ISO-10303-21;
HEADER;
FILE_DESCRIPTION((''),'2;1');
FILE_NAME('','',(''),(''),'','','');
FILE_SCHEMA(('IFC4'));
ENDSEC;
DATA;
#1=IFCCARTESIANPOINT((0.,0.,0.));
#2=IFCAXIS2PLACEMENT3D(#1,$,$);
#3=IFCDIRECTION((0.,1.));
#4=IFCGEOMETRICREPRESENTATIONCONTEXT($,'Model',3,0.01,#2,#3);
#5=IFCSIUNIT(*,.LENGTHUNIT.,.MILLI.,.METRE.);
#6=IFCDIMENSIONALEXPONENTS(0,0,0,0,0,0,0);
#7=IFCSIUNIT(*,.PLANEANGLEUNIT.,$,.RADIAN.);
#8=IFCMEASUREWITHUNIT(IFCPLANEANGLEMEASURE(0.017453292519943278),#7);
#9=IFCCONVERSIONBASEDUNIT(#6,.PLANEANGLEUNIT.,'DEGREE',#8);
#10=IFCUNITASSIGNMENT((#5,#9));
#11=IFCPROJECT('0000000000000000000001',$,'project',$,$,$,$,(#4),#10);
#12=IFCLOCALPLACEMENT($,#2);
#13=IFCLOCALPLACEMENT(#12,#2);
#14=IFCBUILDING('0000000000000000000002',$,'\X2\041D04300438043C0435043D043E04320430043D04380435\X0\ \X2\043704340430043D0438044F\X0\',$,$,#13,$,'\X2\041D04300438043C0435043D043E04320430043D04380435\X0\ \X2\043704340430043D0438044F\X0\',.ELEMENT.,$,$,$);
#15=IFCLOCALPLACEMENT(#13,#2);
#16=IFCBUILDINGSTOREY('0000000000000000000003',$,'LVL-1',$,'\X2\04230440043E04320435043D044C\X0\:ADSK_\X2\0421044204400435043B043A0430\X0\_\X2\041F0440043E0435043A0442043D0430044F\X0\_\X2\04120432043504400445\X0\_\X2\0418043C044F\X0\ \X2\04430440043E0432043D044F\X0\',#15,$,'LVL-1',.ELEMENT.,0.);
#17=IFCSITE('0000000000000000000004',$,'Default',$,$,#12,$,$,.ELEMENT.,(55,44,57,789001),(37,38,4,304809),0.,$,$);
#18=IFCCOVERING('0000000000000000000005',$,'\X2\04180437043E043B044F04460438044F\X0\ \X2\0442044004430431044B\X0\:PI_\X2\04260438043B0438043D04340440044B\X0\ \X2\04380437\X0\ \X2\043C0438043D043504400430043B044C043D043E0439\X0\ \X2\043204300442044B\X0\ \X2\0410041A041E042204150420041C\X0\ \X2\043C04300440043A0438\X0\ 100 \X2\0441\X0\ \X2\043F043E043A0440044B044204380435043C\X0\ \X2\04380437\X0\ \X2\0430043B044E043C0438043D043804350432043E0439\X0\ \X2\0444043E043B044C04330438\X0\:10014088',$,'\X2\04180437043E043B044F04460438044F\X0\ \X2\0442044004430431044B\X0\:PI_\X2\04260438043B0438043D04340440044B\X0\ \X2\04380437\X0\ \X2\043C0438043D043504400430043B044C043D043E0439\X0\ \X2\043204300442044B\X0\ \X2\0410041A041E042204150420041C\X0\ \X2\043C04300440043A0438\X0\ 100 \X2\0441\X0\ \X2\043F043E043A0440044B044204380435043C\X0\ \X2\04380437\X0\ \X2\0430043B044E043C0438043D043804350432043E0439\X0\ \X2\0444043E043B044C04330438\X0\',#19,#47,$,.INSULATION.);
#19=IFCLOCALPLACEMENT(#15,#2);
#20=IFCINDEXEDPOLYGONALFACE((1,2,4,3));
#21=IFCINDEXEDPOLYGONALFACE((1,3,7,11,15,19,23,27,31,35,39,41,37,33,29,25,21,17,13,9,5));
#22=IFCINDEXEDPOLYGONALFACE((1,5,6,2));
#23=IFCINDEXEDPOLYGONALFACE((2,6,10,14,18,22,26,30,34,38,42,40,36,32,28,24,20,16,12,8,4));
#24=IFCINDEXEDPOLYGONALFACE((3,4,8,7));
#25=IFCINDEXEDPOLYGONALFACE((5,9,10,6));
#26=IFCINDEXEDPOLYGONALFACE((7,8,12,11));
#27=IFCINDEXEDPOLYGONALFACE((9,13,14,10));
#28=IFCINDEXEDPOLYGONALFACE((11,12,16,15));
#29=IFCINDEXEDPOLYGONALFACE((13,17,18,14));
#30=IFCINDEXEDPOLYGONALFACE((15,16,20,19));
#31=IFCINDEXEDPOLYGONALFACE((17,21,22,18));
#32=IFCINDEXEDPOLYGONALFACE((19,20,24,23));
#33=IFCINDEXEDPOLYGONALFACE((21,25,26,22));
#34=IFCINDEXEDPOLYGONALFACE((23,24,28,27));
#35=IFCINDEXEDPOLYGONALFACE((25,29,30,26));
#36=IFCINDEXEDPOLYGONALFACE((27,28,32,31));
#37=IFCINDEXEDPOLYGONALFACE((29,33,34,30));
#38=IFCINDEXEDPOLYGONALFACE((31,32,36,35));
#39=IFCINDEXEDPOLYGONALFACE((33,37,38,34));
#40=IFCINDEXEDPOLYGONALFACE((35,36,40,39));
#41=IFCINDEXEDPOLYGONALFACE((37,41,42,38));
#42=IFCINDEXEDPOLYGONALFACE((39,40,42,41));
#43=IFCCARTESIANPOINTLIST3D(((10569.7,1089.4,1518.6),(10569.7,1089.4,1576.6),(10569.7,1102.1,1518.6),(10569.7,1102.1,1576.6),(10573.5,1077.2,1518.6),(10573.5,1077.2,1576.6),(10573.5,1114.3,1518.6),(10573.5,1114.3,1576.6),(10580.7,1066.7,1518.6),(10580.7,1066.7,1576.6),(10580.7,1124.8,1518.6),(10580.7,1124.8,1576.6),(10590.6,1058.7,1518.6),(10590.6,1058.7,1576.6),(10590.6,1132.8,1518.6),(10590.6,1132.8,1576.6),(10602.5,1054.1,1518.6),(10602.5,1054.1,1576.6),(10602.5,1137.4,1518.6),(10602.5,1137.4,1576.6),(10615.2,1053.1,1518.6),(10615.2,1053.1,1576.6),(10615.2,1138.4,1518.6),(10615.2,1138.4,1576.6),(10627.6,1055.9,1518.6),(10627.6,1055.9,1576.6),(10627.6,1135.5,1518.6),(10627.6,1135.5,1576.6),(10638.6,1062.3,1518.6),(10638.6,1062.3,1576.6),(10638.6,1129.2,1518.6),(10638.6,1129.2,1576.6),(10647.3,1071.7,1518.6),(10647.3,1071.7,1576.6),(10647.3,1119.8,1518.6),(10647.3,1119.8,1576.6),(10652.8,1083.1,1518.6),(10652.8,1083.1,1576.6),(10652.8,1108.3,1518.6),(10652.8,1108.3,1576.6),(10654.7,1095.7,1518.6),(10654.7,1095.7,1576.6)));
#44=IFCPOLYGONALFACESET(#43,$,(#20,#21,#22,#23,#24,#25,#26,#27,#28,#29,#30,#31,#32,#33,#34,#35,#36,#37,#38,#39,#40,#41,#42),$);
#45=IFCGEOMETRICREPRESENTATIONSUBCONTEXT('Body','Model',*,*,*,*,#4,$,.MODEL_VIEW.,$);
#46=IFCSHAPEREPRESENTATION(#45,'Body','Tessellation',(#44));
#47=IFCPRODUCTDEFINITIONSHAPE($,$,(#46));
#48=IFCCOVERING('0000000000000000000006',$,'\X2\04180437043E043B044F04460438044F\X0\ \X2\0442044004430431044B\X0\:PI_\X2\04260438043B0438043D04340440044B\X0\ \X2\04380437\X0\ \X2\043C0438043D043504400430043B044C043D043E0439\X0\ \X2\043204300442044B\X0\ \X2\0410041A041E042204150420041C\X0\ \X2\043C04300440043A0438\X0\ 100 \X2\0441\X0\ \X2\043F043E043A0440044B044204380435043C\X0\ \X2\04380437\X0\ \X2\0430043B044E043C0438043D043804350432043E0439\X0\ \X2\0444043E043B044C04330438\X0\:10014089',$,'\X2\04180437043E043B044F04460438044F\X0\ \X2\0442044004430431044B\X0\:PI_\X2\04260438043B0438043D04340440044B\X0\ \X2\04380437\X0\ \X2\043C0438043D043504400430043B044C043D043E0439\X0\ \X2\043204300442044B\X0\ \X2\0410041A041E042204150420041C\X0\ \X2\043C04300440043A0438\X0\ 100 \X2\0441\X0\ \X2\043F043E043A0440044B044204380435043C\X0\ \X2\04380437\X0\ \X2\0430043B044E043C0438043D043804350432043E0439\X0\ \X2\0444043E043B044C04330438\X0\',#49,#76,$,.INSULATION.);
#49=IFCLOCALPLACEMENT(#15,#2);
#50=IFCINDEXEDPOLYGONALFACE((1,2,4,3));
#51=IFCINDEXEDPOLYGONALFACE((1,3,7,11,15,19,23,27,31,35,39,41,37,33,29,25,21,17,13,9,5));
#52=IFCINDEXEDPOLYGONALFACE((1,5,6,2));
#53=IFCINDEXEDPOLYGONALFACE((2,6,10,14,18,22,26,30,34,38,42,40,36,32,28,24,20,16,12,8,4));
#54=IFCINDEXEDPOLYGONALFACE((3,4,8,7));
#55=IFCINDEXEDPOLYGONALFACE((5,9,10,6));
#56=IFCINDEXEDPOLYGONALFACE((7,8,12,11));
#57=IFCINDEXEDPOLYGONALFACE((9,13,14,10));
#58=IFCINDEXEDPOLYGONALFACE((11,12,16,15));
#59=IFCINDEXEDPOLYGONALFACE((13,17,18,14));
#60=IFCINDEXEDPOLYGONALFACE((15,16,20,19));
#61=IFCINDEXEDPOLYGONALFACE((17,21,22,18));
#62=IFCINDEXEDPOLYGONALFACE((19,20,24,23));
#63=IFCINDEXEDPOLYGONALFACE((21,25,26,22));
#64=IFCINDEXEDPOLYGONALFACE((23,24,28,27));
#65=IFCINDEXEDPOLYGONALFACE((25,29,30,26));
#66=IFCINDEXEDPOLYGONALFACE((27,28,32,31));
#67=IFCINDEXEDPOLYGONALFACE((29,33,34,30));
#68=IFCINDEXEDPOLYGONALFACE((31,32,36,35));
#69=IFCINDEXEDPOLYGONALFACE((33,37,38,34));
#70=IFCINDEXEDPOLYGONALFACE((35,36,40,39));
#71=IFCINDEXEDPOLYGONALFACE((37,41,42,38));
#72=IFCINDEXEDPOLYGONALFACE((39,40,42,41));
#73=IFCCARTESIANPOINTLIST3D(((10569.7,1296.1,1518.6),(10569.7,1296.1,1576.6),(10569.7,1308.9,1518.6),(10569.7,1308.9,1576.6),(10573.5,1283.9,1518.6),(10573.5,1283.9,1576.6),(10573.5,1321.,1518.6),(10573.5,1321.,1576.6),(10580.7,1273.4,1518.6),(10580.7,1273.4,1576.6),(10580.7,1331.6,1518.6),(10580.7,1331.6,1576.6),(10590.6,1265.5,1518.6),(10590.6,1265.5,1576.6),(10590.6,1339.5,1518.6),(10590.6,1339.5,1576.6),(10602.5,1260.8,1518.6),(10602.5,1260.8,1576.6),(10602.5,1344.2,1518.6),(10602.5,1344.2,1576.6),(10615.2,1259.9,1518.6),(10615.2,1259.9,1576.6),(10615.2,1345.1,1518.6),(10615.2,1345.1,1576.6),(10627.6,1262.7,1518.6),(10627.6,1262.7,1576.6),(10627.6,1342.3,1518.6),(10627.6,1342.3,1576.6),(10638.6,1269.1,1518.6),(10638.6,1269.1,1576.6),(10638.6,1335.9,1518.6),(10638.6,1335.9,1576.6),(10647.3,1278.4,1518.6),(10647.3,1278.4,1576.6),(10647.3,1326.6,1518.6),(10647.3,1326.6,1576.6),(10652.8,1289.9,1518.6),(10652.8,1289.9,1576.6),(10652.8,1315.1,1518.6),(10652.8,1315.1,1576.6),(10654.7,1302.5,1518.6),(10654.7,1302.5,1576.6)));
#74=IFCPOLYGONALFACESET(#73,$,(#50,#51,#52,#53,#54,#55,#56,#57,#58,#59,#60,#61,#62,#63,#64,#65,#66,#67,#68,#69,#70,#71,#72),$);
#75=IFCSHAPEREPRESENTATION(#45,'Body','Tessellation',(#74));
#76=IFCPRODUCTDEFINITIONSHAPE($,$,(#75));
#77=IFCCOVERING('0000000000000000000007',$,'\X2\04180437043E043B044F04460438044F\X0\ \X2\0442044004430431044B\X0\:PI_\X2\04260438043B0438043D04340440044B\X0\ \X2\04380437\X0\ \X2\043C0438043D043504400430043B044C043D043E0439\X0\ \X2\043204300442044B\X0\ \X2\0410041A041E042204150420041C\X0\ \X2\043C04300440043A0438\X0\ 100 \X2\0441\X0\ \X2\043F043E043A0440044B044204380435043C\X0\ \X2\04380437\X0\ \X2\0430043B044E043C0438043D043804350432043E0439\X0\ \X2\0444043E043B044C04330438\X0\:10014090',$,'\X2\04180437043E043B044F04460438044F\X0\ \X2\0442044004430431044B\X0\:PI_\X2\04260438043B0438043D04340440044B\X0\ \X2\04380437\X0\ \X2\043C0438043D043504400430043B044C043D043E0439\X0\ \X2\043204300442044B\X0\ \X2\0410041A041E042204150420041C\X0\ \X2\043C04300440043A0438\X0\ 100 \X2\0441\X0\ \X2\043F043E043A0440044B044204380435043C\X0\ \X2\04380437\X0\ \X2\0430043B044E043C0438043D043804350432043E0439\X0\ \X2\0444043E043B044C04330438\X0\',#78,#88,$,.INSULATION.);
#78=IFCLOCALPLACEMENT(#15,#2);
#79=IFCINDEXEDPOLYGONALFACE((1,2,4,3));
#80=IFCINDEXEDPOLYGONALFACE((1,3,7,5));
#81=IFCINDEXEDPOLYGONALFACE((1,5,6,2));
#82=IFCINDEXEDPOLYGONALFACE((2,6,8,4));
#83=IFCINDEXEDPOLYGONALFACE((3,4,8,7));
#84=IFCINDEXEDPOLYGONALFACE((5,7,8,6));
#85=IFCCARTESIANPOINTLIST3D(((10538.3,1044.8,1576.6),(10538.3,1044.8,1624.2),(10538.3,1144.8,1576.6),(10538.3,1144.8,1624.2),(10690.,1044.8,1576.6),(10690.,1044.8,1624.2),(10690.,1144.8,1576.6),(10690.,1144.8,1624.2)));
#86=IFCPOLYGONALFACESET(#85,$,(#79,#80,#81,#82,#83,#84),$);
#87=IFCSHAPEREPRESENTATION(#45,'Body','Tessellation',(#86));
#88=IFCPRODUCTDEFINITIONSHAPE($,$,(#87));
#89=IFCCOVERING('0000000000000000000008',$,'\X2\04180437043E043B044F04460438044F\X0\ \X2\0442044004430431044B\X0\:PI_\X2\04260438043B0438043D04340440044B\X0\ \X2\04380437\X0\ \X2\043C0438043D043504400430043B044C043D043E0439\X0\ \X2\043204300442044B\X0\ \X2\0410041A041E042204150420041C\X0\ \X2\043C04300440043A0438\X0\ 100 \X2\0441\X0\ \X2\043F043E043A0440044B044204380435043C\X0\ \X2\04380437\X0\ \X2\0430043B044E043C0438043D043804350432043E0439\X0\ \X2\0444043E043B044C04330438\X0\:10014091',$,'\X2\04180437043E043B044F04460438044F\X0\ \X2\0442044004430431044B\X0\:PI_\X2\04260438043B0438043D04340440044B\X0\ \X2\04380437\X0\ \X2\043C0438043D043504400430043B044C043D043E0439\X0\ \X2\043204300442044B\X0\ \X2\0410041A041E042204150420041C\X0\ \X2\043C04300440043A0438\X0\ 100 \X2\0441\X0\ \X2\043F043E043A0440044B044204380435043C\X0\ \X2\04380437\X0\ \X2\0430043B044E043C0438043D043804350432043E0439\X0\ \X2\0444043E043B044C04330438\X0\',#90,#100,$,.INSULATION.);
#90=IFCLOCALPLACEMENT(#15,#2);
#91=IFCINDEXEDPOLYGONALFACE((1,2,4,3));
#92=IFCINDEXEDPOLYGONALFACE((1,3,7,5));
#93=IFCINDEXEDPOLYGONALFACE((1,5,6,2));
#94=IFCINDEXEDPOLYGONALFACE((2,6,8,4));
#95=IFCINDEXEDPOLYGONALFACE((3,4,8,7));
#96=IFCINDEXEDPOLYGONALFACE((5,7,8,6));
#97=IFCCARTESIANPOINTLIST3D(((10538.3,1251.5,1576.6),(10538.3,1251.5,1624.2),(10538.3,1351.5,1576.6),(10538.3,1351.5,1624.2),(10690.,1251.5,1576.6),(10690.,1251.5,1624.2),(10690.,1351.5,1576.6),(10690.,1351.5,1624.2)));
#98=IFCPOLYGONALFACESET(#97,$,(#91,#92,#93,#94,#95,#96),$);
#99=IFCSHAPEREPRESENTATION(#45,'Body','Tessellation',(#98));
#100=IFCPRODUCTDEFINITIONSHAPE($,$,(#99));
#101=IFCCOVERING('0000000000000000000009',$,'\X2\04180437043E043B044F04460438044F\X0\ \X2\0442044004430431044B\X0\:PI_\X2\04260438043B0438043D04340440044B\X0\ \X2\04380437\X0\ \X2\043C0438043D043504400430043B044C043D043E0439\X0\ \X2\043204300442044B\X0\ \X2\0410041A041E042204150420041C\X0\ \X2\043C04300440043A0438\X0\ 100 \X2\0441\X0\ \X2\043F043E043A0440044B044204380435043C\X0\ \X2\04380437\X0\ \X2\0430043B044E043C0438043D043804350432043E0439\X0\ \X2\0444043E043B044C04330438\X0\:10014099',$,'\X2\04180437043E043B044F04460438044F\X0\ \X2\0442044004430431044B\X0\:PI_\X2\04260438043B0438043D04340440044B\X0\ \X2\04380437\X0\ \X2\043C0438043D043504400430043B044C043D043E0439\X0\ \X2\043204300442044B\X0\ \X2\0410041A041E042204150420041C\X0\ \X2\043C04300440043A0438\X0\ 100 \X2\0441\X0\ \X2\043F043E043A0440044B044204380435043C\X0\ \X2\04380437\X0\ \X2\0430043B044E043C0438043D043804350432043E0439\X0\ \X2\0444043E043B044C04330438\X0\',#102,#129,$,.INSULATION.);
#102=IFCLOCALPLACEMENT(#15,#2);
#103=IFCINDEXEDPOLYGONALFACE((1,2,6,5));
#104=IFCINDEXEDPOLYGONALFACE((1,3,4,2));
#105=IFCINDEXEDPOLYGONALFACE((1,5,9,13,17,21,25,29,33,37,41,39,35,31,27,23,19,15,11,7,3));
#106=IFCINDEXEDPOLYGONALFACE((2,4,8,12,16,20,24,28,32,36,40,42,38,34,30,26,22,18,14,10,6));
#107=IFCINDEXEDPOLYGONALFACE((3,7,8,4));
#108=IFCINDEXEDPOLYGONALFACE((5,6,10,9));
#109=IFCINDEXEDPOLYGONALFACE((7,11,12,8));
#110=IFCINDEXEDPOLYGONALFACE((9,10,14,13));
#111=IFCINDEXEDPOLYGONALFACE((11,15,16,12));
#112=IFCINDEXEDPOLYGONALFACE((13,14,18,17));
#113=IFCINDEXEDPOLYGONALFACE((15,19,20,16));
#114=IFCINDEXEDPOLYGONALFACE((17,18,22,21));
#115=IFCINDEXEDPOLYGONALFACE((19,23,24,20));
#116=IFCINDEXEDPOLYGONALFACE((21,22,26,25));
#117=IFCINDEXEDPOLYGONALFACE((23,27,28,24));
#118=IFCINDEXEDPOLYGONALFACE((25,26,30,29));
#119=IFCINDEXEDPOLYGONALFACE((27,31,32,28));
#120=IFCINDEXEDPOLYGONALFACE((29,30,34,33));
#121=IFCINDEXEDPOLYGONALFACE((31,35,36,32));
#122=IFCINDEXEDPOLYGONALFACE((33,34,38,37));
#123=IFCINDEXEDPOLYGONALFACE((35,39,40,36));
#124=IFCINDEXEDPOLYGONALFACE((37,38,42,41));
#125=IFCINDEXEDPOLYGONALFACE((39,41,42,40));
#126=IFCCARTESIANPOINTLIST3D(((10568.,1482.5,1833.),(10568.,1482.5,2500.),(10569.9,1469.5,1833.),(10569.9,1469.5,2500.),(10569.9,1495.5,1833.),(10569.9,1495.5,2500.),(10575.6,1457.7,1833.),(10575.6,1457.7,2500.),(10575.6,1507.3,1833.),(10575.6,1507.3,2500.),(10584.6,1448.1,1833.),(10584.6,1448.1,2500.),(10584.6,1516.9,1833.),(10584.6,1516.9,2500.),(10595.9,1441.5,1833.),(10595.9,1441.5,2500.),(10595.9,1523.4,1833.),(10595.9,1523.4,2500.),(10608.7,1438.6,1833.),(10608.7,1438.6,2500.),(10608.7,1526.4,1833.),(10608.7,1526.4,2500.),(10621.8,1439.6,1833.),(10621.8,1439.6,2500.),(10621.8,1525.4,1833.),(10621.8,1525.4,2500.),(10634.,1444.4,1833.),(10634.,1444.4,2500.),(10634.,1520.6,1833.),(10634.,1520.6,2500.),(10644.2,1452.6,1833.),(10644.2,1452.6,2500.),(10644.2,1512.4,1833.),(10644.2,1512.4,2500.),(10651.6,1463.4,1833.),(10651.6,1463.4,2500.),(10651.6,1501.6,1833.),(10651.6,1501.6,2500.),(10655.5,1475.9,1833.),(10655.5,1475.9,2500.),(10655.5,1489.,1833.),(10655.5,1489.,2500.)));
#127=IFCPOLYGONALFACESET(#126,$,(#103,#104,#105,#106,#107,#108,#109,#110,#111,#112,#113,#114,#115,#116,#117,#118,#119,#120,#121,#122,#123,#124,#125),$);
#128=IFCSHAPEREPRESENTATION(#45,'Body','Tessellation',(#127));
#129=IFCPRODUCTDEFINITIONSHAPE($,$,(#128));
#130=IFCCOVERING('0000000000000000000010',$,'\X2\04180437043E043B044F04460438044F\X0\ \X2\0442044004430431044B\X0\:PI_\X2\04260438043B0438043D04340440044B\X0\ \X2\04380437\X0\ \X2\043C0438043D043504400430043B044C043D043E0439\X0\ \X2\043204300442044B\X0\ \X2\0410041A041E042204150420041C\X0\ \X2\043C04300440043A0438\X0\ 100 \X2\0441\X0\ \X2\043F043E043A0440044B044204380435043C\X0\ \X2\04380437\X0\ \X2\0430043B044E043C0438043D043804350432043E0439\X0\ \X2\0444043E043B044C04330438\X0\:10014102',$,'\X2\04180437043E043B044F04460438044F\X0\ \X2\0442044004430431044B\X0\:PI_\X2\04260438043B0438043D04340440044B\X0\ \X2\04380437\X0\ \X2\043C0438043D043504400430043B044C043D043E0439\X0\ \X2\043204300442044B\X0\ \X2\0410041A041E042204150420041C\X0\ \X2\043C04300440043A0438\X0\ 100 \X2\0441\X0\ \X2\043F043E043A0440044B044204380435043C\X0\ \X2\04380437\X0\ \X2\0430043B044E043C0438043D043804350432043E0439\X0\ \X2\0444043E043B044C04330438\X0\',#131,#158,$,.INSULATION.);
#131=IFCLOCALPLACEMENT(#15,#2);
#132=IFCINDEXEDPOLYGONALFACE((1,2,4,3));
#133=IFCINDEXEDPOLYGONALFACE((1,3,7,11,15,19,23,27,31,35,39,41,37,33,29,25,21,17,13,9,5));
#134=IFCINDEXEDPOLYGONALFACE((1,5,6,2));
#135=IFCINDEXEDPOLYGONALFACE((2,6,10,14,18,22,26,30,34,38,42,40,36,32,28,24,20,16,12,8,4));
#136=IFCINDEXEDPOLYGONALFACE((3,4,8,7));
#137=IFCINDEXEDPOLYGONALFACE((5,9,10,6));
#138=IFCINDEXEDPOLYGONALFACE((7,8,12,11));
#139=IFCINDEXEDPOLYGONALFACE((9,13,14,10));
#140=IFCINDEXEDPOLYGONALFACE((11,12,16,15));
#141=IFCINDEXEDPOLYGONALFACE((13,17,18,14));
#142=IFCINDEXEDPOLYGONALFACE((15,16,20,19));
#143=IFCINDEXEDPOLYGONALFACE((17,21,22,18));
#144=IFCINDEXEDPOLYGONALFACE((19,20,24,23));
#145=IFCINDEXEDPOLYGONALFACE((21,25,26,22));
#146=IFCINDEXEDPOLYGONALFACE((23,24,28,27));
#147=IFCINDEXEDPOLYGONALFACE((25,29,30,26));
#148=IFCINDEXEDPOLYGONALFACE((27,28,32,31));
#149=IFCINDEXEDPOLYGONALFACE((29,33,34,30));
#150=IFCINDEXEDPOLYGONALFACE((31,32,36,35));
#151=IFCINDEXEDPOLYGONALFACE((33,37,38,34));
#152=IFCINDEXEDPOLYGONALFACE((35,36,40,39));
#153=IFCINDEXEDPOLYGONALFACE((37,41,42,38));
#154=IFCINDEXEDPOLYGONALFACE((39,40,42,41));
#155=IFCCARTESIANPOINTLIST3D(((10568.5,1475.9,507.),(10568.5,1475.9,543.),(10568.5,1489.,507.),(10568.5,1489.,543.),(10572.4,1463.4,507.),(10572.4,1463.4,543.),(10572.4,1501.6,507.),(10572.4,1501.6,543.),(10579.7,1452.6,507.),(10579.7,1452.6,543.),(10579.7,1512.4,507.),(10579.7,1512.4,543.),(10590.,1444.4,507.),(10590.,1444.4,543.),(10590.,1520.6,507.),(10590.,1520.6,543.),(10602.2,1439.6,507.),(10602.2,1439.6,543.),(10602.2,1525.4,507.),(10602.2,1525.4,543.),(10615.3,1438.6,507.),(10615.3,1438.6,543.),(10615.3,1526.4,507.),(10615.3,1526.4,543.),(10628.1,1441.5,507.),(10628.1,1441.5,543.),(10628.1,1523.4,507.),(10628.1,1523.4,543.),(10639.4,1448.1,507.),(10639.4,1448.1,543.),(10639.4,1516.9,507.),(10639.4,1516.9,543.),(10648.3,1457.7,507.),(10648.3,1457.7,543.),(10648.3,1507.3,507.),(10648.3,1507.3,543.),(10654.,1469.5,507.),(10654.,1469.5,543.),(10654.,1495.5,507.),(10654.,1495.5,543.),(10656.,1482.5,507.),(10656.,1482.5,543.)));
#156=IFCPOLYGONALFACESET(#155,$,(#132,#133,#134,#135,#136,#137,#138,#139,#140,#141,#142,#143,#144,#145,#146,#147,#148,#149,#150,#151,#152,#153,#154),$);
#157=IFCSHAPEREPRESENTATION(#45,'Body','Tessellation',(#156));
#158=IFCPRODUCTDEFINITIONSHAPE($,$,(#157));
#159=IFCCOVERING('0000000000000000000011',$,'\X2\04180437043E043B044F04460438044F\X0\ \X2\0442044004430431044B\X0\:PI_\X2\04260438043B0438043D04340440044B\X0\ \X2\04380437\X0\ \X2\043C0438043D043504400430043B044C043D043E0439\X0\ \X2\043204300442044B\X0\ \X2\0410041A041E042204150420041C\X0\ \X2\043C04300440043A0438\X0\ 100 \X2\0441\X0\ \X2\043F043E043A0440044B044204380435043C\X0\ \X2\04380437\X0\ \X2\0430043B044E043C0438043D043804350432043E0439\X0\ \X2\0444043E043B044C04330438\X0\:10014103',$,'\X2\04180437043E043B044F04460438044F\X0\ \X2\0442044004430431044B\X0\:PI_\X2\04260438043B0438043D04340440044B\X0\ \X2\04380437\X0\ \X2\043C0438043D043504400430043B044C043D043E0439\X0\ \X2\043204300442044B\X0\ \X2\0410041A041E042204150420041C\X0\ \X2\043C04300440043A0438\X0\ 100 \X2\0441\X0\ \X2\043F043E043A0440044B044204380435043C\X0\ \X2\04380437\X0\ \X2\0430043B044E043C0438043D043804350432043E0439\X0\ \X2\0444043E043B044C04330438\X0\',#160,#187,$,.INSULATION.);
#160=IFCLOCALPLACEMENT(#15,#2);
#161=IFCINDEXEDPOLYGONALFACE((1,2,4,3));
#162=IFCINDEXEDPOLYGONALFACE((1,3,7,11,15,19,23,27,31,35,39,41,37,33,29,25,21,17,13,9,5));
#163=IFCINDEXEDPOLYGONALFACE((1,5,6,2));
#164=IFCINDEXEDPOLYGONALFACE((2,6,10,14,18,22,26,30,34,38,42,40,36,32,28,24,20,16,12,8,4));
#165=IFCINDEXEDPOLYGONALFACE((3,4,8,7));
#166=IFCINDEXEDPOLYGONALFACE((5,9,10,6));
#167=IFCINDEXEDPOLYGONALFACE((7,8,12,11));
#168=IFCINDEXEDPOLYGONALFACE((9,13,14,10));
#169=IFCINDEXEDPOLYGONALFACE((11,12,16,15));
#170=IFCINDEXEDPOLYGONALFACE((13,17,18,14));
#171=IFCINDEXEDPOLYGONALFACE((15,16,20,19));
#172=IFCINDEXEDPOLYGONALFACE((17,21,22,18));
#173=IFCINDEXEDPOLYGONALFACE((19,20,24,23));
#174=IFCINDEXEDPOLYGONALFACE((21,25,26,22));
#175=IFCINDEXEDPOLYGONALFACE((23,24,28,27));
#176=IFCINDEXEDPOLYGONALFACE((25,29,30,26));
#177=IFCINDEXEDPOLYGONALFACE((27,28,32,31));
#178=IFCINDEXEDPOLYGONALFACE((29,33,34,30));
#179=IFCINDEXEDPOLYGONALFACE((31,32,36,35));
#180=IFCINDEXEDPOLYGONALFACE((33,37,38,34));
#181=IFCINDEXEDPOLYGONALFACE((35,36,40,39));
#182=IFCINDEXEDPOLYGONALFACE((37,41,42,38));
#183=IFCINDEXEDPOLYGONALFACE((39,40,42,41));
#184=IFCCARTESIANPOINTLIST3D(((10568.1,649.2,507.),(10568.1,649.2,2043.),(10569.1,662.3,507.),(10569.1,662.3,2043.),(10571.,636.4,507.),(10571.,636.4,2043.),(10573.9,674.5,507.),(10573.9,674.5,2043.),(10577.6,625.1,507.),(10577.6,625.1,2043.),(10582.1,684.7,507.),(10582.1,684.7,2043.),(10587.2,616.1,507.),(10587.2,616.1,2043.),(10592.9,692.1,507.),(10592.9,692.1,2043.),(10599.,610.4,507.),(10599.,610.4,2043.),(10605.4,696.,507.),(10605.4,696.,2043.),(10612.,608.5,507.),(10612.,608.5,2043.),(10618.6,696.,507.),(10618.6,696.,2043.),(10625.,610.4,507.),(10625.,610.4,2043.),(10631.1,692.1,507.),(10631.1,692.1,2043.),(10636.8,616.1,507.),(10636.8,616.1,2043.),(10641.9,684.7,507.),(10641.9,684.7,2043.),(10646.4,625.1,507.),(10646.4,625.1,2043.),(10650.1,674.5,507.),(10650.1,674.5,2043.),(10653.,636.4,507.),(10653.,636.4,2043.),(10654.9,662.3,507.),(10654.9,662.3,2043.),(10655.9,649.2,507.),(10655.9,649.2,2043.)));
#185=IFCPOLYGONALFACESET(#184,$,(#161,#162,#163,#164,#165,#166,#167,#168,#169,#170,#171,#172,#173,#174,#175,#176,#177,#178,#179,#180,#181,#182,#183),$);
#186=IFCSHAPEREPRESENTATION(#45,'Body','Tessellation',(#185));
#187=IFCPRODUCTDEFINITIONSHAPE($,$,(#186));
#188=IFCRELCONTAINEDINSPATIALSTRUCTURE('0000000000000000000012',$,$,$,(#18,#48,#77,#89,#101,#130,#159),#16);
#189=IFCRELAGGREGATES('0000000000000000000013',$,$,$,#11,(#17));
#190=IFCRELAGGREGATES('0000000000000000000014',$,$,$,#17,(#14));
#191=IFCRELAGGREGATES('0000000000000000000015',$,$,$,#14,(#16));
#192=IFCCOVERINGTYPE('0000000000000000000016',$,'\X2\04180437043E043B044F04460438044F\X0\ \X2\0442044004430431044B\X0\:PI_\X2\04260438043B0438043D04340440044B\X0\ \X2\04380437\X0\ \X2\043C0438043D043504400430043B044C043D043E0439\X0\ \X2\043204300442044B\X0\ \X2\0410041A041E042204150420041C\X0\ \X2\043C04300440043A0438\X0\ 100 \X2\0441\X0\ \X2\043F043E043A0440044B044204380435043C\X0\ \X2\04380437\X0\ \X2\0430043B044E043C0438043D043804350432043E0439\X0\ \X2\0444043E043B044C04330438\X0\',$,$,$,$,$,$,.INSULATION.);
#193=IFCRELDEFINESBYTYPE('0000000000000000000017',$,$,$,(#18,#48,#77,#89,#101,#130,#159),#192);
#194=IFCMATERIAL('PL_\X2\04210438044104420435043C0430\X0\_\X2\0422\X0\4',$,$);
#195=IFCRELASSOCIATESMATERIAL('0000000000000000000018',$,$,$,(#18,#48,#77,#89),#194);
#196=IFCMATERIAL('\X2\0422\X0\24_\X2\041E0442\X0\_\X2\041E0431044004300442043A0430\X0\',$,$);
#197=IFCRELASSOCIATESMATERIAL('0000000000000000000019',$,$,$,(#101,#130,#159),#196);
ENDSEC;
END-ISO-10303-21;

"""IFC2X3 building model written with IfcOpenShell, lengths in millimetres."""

from ifc_helpers import new_model, entity, si_unit, converted_unit, direction, frame, frame_2d, origin, origin_2d_with_axis, place, context, subcontext, project, spatial, rectangle, circle, extrude, material, type_object, element, save


model = new_model("IFC2X3")

# Units and contexts
model_context = context("Model", 3, precision=0.01, world=origin(), true_north=direction((0.0, 1.0)))
body_context = subcontext(model_context, "Body", "Model", "MODEL_VIEW")
ifc_project = project(units=[si_unit("LENGTHUNIT", "METRE", prefix="MILLI"), converted_unit("PLANEANGLEUNIT", "DEGREE", entity("IfcPlaneAngleMeasure", 0.017453292519943278), si_unit("PLANEANGLEUNIT", "RADIAN"), dimensions=[0, 0, 0, 0, 0, 0, 0])], contexts=[model_context])

# Site, building, storey
site_placement = place(None, origin())
site = spatial("IfcSite", under=ifc_project, at=site_placement, Name="Default", CompositionType="ELEMENT", RefLatitude=(55, 44, 57, 789001), RefLongitude=(37, 38, 4, 304809), RefElevation=0.0)
building_placement = place(site_placement, origin())
building = spatial("IfcBuilding", under=site, at=building_placement, Name="Наименование здания", LongName="Наименование здания", CompositionType="ELEMENT")
storey_placement = place(building_placement, origin())
storey = spatial("IfcBuildingStorey", under=building, at=storey_placement, Name="LVL-1", ObjectType="Уровень:ADSK_Стрелка_Проектная_Вверх_Имя уровня", LongName="LVL-1", CompositionType="ELEMENT", Elevation=0.0)

# Coverings
ifc_material_1 = material(Name="PL_Система_Т4")
covering_type = type_object("IfcCoveringType", Name="Изоляция трубы:PI_Цилиндры из минеральной ваты АКОТЕРМ марки 100 с покрытием из алюминиевой фольги", PredefinedType="INSULATION")
covering_1_placement = place(storey_placement, origin())
element("IfcCovering", 1, at=covering_1_placement, inside=storey, type_object=covering_type, material=ifc_material_1, Name="Изоляция трубы:PI_Цилиндры из минеральной ваты АКОТЕРМ марки 100 с покрытием из алюминиевой фольги:10014088", ObjectType="Изоляция трубы:PI_Цилиндры из минеральной ваты АКОТЕРМ марки 100 с покрытием из алюминиевой фольги", PredefinedType="INSULATION", context=body_context, shape_type="SweptSolid", body=[
    extrude(circle(Radius=42.8, at=frame_2d((0.0, 0.0), x_axis=(1.0, 0.0))), frame((10612.0, 1095.7, 1518.6)), (0.0, 0.0, 1.0), 58.0),
])
covering_2_placement = place(storey_placement, origin())
element("IfcCovering", 2, at=covering_2_placement, inside=storey, type_object=covering_type, material=ifc_material_1, Name="Изоляция трубы:PI_Цилиндры из минеральной ваты АКОТЕРМ марки 100 с покрытием из алюминиевой фольги:10014089", ObjectType="Изоляция трубы:PI_Цилиндры из минеральной ваты АКОТЕРМ марки 100 с покрытием из алюминиевой фольги", PredefinedType="INSULATION", context=body_context, shape_type="SweptSolid", body=[
    extrude(circle(Radius=42.8, at=origin_2d_with_axis()), frame((10612.0, 1302.5, 1518.6)), (0.0, 0.0, 1.0), 58.0),
])
covering_3_placement = place(storey_placement, origin())
element("IfcCovering", 3, at=covering_3_placement, inside=storey, type_object=covering_type, material=ifc_material_1, Name="Изоляция трубы:PI_Цилиндры из минеральной ваты АКОТЕРМ марки 100 с покрытием из алюминиевой фольги:10014090", ObjectType="Изоляция трубы:PI_Цилиндры из минеральной ваты АКОТЕРМ марки 100 с покрытием из алюминиевой фольги", PredefinedType="INSULATION", context=body_context, shape_type="SweptSolid", body=[
    extrude(rectangle(XDim=151.7, YDim=100.0, at=frame_2d((0.0, 0.0), x_axis=(1.0, 0.0))), frame((10614.1, 1094.8, 1576.6)), (0.0, 0.0, 1.0), 47.7),
])
covering_4_placement = place(storey_placement, origin())
element("IfcCovering", 4, at=covering_4_placement, inside=storey, type_object=covering_type, material=ifc_material_1, Name="Изоляция трубы:PI_Цилиндры из минеральной ваты АКОТЕРМ марки 100 с покрытием из алюминиевой фольги:10014091", ObjectType="Изоляция трубы:PI_Цилиндры из минеральной ваты АКОТЕРМ марки 100 с покрытием из алюминиевой фольги", PredefinedType="INSULATION", context=body_context, shape_type="SweptSolid", body=[
    extrude(rectangle(XDim=151.7, YDim=100.0, at=frame_2d((0.0, 0.0), x_axis=(1.0, 0.0))), frame((10614.1, 1301.5, 1576.6)), (0.0, 0.0, 1.0), 47.7),
])
ifc_material_2 = material(Name="Т24_От_Обратка")
covering_5_placement = place(storey_placement, origin())
element("IfcCovering", 5, at=covering_5_placement, inside=storey, type_object=covering_type, material=ifc_material_2, Name="Изоляция трубы:PI_Цилиндры из минеральной ваты АКОТЕРМ марки 100 с покрытием из алюминиевой фольги:10014099", ObjectType="Изоляция трубы:PI_Цилиндры из минеральной ваты АКОТЕРМ марки 100 с покрытием из алюминиевой фольги", PredefinedType="INSULATION", context=body_context, shape_type="SweptSolid", body=[
    extrude(circle(Radius=44.0, at=frame_2d((0.0, 0.0), x_axis=(1.0, 0.0))), frame((10612.0, 1482.5, 1833.0), z_axis=(0.0, 0.0, 1.0), x_axis=(-1.0, 0.0, 0.0)), (0.0, 0.0, 1.0), 667.0),
])
covering_6_placement = place(storey_placement, origin())
element("IfcCovering", 6, at=covering_6_placement, inside=storey, type_object=covering_type, material=ifc_material_2, Name="Изоляция трубы:PI_Цилиндры из минеральной ваты АКОТЕРМ марки 100 с покрытием из алюминиевой фольги:10014102", ObjectType="Изоляция трубы:PI_Цилиндры из минеральной ваты АКОТЕРМ марки 100 с покрытием из алюминиевой фольги", PredefinedType="INSULATION", context=body_context, shape_type="SweptSolid", body=[
    extrude(circle(Radius=44.0, at=frame_2d((0.0, 0.0), x_axis=(1.0, 0.0))), frame((10612.0, 1482.5, 507.0)), (0.0, 0.0, 1.0), 36.0),
])
covering_7_placement = place(storey_placement, origin())
element("IfcCovering", 7, at=covering_7_placement, inside=storey, type_object=covering_type, material=ifc_material_2, Name="Изоляция трубы:PI_Цилиндры из минеральной ваты АКОТЕРМ марки 100 с покрытием из алюминиевой фольги:10014103", ObjectType="Изоляция трубы:PI_Цилиндры из минеральной ваты АКОТЕРМ марки 100 с покрытием из алюминиевой фольги", PredefinedType="INSULATION", context=body_context, shape_type="SweptSolid", body=[
    extrude(circle(Radius=44.0, at=frame_2d((0.0, 0.0), x_axis=(1.0, 0.0))), frame((10612.0, 652.5, 507.0), z_axis=(0.0, 0.0, 1.0), x_axis=(0.0, -1.0, 0.0)), (0.0, 0.0, 1.0), 1536.0),
])

save(model, "model.ifc")
